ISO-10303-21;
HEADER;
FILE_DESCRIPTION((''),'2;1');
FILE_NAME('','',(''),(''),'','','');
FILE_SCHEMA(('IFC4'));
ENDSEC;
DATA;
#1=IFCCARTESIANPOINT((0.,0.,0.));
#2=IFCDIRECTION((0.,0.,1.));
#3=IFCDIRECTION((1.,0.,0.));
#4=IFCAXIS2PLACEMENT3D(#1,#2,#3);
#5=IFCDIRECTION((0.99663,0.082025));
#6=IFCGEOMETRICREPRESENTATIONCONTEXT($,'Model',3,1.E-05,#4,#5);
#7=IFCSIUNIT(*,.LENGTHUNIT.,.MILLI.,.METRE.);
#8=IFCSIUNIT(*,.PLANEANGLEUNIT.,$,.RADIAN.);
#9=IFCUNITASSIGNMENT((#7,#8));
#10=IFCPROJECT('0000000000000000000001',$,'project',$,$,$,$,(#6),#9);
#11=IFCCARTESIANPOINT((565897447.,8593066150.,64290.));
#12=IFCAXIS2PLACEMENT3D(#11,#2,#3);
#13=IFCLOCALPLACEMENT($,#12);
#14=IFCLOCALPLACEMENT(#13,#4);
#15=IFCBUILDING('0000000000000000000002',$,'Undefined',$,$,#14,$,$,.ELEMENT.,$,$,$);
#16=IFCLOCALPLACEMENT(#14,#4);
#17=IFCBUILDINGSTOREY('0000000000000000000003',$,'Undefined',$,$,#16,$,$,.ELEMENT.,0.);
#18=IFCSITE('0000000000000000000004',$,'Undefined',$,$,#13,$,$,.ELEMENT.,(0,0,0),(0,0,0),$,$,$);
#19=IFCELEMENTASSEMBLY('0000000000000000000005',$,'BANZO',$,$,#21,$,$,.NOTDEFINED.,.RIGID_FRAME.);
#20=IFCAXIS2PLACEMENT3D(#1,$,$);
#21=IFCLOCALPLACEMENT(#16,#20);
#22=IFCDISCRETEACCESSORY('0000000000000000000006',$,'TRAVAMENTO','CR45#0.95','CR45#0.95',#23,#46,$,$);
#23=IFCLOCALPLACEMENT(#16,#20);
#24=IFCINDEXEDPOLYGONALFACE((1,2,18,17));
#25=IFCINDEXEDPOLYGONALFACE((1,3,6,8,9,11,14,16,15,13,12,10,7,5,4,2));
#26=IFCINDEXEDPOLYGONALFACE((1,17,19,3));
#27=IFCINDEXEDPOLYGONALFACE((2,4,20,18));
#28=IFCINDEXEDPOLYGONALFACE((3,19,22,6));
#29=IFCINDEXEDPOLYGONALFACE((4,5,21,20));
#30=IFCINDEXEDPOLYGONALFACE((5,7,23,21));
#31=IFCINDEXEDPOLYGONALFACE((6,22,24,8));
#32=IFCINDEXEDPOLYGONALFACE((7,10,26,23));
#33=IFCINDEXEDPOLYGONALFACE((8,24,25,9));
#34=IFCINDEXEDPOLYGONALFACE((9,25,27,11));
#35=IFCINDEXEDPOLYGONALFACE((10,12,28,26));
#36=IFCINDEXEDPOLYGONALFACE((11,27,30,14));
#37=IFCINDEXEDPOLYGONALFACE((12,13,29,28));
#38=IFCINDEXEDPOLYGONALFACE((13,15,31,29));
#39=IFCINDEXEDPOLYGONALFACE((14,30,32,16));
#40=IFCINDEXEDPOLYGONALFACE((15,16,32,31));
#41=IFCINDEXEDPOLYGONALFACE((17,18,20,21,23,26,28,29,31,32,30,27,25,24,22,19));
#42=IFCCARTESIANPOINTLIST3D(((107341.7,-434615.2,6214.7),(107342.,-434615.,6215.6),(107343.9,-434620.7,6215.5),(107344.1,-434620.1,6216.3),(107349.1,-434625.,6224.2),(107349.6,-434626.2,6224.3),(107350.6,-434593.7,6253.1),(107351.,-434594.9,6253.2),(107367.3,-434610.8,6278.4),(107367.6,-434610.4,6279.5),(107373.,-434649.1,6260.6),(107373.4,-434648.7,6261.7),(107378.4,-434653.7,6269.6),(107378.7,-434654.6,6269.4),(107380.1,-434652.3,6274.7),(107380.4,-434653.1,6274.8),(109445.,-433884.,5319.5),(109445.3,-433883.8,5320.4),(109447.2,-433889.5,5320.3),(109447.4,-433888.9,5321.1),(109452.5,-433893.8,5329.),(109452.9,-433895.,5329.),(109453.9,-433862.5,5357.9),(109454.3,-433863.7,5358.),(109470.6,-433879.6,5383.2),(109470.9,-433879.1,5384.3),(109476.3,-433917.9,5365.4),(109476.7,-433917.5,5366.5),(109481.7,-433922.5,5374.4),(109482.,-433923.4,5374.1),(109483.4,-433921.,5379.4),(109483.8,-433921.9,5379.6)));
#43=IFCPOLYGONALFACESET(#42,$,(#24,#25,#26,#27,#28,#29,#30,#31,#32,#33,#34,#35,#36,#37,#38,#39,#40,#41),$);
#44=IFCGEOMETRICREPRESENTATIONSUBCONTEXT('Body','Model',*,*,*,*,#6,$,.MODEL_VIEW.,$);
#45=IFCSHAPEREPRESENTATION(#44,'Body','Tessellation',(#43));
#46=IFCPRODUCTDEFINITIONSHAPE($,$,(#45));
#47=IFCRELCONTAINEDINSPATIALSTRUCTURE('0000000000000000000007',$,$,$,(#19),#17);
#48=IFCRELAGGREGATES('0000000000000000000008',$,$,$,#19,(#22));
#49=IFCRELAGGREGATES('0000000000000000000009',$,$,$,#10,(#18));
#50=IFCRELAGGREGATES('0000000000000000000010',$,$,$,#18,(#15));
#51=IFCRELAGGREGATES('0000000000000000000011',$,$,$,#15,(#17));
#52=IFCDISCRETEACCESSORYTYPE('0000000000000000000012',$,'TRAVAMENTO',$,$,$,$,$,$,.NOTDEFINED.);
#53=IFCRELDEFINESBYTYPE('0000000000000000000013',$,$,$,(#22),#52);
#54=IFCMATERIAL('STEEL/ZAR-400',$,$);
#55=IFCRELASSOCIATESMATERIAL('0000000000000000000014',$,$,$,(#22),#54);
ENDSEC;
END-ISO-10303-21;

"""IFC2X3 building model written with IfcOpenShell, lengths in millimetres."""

from ifc_helpers import new_model, si_unit, direction, frame, origin_with_axes, place, context, subcontext, project, spatial, polyline, outline, extrude, material, type_object, element, aggregate, save


model = new_model("IFC2X3")

# Units and contexts
model_context = context("Model", 3, precision=1e-05, world=origin_with_axes(), true_north=direction((0.99663, 0.082025)))
body_context = subcontext(model_context, "Body", "Model", "MODEL_VIEW")
ifc_project = project(units=[si_unit("LENGTHUNIT", "METRE", prefix="MILLI"), si_unit("PLANEANGLEUNIT", "RADIAN")], contexts=[model_context])

# Site, building, storey
site_placement = place(None, frame((565897447.0, 8593066150.0, 64290.0), z_axis=(0.0, 0.0, 1.0), x_axis=(1.0, 0.0, 0.0)))
site = spatial("IfcSite", under=ifc_project, at=site_placement, Name="Undefined", CompositionType="ELEMENT", RefLatitude=(0, 0, 0), RefLongitude=(0, 0, 0))
building_placement = place(site_placement, origin_with_axes())
building = spatial("IfcBuilding", under=site, at=building_placement, Name="Undefined", CompositionType="ELEMENT")
storey_placement = place(building_placement, origin_with_axes())
storey = spatial("IfcBuildingStorey", under=building, at=storey_placement, Name="Undefined", CompositionType="ELEMENT", Elevation=0.0)

# Element assembly, discrete accessory
assembly_placement = place(storey_placement, origin_with_axes())
assembly = element("IfcElementAssembly", 1, at=assembly_placement, inside=storey, Name="BANZO", AssemblyPlace="NOTDEFINED", PredefinedType="RIGID_FRAME")
ifc_material_1 = material(Name="STEEL/ZAR-400")
discrete_accessory_type_1 = type_object("IfcDiscreteAccessoryType", Name="TRAVAMENTO")
discrete_accessory_1_placement = place(assembly_placement, frame((109463.7, -433888.8, 5359.4), z_axis=(-0.05151, 0.82934, 0.556366), x_axis=(-0.876377, -0.30467, 0.373015)))
discrete_accessory_1 = element("IfcDiscreteAccessory", 2, at=discrete_accessory_1_placement, type_object=discrete_accessory_type_1, material=ifc_material_1, Name="TRAVAMENTO", Description="CR45#0.95", ObjectType="CR45#0.95", context=body_context, shape_type="SweptSolid", body=[
    extrude(outline(polyline([(-35.5, -20.5), (-24.9, -20.5), (-17.4, 21.5), (18.1, 21.5), (25.6, -20.5), (36.2, -20.5), (40.1, -16.6), (40.8, -17.3), (36.6, -21.5), (24.8, -21.5), (17.3, 20.5), (-16.6, 20.5), (-24.1, -21.5), (-35.9, -21.5), (-40.1, -17.3), (-39.4, -16.6), (-35.5, -20.5)])), frame((2400.0, 0.0, 0.0), z_axis=(-1.0, 0.0, 0.0), x_axis=(0.0, -1.0, 0.0)), (0.0, 0.0, 1.0), 2400.0),
])
aggregate(assembly, [discrete_accessory_1])

save(model, "model.ifc")
